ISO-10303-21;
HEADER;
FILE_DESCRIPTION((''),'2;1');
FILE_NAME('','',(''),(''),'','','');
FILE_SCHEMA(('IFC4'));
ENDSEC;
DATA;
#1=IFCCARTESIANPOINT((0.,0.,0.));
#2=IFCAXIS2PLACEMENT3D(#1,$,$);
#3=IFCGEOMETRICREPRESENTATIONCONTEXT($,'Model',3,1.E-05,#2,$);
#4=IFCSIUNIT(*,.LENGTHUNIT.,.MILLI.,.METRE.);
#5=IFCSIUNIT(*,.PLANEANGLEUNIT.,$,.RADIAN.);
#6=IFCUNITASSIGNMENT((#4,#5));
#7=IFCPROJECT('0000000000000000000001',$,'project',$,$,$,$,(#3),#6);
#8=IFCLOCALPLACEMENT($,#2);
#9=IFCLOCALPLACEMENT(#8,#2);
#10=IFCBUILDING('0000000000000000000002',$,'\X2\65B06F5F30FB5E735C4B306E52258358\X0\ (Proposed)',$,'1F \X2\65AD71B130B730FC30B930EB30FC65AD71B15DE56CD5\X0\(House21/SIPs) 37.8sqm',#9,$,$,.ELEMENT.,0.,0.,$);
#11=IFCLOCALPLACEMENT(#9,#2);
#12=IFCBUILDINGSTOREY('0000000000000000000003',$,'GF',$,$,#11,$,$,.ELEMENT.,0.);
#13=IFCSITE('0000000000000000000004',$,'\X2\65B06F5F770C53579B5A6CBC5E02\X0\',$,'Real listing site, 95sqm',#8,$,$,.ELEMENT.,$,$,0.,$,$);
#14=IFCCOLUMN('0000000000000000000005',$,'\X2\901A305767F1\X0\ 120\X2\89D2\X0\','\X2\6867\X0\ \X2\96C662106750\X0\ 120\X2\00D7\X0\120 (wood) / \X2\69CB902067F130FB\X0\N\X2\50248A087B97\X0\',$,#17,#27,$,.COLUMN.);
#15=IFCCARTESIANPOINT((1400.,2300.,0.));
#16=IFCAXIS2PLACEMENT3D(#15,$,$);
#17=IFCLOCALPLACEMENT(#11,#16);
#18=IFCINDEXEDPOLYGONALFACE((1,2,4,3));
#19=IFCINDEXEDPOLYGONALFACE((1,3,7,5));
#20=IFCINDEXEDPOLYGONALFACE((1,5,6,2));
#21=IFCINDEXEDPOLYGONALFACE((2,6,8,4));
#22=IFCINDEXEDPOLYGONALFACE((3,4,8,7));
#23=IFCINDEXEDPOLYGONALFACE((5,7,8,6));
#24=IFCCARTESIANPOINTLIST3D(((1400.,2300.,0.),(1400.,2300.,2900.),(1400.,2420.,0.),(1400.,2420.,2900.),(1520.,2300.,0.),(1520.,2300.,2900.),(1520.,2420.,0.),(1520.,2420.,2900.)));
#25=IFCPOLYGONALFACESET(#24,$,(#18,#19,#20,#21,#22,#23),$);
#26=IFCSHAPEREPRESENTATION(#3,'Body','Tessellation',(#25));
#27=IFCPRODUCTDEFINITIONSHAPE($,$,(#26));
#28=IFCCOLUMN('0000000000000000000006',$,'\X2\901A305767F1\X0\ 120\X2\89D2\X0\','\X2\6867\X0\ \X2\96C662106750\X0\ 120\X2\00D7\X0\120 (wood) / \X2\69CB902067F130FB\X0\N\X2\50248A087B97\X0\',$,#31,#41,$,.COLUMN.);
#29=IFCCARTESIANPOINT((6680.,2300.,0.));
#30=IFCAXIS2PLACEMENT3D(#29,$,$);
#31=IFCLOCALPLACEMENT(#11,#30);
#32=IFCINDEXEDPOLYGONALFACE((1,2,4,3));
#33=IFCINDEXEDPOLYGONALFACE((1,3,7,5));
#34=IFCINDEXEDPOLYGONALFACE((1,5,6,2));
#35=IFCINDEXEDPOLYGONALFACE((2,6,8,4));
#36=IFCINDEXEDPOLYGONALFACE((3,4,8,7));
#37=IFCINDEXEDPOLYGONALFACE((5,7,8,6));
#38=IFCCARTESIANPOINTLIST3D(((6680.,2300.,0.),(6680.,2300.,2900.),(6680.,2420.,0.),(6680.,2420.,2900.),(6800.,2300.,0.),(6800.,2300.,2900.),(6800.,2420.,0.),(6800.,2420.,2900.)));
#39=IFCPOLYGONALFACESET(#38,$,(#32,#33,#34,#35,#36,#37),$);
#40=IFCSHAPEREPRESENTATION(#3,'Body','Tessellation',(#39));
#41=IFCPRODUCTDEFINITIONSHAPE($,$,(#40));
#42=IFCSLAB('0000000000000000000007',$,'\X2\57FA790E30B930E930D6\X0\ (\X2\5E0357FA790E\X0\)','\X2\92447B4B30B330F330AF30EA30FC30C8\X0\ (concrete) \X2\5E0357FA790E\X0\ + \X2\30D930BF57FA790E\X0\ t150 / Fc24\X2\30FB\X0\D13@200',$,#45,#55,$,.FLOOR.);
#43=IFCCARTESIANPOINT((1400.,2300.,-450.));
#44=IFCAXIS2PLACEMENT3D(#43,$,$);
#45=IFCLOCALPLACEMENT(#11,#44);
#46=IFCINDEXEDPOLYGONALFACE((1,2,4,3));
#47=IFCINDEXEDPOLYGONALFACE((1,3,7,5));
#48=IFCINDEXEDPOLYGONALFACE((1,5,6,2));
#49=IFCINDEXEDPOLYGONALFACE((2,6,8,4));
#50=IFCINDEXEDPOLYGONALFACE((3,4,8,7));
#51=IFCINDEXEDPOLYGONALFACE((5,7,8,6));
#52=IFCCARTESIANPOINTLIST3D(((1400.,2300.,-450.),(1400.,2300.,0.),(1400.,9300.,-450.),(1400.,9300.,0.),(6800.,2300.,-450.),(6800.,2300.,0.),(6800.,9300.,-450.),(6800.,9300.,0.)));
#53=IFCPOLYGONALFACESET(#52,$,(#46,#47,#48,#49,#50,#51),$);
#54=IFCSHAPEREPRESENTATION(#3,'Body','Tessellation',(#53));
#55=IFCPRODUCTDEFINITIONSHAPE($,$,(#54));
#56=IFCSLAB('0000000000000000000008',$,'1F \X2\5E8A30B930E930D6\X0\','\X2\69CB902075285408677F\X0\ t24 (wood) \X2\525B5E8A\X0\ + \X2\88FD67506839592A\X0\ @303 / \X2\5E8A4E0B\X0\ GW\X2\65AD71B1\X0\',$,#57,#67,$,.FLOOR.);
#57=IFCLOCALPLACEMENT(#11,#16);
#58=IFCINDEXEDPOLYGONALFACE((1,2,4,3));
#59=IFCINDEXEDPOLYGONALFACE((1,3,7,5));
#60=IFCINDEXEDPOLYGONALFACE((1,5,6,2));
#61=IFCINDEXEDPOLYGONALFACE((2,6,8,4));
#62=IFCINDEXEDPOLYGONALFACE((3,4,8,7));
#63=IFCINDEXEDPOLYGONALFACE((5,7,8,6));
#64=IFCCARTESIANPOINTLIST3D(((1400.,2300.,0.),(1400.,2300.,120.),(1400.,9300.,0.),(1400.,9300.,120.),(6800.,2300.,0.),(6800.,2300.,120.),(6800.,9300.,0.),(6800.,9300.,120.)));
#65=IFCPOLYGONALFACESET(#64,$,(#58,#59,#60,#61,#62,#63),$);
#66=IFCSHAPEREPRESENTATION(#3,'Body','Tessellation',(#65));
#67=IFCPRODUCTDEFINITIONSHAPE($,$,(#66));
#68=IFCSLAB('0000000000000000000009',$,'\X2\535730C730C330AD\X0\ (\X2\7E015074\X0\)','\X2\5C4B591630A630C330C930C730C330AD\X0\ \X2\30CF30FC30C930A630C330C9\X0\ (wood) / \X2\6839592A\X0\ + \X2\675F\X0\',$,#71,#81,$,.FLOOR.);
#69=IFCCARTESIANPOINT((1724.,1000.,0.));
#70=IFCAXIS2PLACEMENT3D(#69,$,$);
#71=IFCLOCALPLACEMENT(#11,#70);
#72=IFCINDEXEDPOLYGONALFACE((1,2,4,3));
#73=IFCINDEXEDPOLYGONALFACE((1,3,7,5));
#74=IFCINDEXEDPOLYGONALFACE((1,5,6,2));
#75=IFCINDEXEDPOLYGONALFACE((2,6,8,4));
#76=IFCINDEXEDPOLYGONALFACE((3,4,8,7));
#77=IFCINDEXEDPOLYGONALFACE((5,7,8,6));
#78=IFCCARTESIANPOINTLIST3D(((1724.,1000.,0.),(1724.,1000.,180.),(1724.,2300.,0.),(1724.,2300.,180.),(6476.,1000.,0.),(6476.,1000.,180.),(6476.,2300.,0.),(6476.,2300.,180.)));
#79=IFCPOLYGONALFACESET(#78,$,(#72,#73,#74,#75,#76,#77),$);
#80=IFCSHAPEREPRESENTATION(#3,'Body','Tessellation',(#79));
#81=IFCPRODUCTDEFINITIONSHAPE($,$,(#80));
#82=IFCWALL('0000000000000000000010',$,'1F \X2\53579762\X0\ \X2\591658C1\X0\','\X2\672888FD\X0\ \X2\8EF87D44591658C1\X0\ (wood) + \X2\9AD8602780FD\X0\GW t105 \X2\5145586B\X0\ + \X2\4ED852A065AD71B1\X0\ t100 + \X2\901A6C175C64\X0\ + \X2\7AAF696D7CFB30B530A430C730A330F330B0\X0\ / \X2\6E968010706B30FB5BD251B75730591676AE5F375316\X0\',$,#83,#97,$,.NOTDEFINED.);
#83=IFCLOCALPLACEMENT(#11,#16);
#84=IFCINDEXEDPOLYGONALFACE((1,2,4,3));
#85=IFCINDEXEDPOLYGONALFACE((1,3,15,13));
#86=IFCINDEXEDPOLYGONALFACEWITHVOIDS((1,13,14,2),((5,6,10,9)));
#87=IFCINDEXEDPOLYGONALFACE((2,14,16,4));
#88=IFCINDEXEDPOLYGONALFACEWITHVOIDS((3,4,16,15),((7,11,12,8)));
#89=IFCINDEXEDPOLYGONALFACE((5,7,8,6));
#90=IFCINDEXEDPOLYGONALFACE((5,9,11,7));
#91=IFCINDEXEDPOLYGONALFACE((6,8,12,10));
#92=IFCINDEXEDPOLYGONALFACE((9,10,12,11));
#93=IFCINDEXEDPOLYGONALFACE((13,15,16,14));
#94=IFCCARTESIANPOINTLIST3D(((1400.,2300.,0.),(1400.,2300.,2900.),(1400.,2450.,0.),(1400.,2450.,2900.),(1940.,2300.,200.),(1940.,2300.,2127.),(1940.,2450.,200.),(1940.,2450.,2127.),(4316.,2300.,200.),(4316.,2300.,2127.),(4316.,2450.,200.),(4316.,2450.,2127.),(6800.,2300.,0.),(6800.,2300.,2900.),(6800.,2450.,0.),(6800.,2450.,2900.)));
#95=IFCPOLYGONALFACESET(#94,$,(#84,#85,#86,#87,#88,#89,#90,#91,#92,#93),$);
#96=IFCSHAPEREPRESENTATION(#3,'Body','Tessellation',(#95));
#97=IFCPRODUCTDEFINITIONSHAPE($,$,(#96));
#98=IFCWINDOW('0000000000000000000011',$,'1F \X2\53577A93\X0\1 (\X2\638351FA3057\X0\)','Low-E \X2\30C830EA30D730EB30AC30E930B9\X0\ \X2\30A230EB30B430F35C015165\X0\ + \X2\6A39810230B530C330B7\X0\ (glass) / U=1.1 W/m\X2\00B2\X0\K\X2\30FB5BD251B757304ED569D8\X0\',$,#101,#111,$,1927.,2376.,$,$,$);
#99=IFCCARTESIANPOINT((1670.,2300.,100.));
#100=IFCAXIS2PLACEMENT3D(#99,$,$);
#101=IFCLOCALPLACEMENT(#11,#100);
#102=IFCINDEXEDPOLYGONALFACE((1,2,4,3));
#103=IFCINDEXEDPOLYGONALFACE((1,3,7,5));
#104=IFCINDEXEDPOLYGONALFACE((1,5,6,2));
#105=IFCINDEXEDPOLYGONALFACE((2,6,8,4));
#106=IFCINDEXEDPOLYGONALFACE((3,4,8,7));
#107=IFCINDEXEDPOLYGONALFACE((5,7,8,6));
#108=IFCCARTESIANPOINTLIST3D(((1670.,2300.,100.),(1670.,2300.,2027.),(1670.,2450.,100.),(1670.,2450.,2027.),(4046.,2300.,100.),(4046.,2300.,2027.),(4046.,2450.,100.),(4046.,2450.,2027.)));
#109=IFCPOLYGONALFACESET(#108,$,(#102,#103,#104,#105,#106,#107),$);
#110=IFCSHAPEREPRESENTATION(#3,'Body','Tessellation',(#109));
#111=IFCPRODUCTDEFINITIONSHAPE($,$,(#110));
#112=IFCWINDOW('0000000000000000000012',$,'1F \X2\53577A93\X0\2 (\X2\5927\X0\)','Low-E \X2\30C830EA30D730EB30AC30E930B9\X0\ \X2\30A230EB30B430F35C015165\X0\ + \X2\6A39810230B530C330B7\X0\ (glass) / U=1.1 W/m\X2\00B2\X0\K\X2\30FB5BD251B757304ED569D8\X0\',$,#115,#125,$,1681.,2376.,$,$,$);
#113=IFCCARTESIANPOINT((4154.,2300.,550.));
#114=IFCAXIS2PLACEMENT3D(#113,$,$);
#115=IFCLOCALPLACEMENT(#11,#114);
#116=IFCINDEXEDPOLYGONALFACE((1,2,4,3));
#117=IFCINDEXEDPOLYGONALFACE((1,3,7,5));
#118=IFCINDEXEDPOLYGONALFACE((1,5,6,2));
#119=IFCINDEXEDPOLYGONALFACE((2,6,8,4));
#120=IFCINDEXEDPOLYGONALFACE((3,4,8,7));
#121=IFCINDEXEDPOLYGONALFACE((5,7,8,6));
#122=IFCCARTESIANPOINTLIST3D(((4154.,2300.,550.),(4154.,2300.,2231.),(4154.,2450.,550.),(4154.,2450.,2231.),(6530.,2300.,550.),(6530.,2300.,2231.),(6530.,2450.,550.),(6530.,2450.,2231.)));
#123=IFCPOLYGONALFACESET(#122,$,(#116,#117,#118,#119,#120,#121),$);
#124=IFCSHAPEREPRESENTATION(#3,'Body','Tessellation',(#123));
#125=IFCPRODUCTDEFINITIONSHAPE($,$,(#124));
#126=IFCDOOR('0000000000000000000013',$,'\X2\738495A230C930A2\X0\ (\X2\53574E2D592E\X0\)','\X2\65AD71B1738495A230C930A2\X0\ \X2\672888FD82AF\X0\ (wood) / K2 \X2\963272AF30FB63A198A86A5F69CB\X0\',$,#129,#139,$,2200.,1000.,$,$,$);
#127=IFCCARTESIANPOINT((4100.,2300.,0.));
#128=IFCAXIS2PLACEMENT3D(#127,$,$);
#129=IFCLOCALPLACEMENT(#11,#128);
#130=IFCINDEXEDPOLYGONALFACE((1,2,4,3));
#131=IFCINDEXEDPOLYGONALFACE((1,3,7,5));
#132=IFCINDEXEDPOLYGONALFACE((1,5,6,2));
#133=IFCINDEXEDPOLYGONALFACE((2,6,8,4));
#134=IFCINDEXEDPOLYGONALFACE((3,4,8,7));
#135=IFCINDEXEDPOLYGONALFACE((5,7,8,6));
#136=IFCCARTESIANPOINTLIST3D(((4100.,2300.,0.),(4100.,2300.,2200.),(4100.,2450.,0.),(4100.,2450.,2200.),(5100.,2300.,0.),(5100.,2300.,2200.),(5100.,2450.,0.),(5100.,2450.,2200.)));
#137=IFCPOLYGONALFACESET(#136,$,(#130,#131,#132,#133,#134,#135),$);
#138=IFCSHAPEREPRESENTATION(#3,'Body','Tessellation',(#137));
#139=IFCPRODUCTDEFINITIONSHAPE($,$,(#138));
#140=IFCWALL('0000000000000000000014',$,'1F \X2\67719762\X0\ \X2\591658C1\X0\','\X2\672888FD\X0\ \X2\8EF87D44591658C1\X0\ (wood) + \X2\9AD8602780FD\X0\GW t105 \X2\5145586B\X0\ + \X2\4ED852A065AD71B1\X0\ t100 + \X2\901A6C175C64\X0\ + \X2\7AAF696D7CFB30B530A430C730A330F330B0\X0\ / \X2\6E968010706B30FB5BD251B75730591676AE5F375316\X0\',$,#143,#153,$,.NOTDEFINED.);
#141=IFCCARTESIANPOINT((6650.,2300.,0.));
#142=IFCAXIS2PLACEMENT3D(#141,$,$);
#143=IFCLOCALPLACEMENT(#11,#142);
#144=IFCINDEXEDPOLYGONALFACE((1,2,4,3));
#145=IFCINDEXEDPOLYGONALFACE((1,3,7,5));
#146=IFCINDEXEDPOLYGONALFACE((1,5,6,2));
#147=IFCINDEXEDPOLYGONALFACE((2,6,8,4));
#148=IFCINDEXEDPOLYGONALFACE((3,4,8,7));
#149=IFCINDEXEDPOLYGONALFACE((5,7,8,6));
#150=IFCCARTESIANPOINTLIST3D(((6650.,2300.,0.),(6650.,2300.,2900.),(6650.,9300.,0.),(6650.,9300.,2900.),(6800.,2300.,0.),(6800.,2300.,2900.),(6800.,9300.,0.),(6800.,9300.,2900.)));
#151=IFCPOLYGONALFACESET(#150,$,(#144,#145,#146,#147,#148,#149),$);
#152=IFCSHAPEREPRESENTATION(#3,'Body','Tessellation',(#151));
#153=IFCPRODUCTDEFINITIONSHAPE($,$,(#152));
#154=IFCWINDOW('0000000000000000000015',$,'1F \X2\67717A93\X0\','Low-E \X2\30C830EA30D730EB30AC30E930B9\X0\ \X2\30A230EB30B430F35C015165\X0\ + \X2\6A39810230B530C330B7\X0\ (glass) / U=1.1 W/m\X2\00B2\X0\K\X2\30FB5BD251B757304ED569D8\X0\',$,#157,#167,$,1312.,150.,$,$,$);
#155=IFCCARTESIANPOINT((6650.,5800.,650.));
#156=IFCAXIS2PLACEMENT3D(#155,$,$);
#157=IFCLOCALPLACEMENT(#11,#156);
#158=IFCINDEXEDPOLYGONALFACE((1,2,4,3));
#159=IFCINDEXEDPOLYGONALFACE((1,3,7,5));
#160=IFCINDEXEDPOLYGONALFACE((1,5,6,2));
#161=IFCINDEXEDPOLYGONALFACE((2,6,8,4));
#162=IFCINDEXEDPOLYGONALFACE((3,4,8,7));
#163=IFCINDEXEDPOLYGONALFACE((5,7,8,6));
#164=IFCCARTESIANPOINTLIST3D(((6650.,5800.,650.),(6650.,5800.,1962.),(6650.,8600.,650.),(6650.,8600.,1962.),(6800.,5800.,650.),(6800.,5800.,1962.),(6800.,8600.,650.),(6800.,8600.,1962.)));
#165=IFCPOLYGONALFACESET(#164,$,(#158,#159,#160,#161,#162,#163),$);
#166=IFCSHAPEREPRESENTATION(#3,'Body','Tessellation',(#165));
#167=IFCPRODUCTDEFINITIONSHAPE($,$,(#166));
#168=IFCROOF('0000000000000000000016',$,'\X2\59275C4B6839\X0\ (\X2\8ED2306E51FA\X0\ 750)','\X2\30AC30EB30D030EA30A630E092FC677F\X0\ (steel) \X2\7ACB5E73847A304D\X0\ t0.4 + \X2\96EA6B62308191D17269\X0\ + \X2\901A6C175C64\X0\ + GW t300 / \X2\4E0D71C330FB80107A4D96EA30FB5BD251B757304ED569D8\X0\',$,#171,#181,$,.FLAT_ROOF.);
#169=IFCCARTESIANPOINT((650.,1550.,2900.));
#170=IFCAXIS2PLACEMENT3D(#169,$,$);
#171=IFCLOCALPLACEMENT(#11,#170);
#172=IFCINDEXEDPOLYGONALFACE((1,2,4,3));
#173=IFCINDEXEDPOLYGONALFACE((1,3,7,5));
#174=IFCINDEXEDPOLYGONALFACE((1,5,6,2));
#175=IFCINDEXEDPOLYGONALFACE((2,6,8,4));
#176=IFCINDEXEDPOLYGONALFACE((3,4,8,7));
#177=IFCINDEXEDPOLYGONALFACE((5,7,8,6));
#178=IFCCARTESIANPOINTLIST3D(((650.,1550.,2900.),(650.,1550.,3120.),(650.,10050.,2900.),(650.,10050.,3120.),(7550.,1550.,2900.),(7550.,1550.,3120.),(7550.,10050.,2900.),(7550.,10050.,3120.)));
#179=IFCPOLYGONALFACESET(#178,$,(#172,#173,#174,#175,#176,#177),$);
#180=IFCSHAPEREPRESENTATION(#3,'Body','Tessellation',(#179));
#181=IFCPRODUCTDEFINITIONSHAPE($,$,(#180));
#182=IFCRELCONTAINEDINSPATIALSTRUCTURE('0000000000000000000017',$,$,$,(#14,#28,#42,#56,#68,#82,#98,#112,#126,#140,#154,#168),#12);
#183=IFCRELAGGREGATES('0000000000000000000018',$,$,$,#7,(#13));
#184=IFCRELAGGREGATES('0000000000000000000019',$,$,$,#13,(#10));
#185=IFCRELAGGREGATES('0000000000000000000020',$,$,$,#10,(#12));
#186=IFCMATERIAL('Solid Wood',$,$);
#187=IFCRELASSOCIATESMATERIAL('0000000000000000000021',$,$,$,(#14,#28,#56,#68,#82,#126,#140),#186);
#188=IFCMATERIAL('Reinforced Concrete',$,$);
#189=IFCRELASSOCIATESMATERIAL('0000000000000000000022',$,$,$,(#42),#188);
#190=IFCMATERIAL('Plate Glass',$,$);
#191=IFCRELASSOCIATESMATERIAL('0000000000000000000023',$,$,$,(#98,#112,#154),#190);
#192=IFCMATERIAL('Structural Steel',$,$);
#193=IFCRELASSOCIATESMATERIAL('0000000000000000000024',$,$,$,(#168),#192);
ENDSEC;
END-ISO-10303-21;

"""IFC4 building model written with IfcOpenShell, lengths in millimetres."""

from ifc_helpers import new_model, si_unit, frame, frame_2d, origin, place, context, project, spatial, rectangle, extrude, material, element, fill, save


model = new_model("IFC4")

# Units and contexts
model_context = context("Model", 3, precision=1e-05, world=origin())
ifc_project = project(units=[si_unit("LENGTHUNIT", "METRE", prefix="MILLI"), si_unit("PLANEANGLEUNIT", "RADIAN")], contexts=[model_context])

# Site, building, storey
site_placement = place(None, origin())
site = spatial("IfcSite", under=ifc_project, at=site_placement, Name="新潟県南魚沼市", ObjectType="Real listing site, 95sqm", CompositionType="ELEMENT", RefElevation=0.0)
building_placement = place(site_placement, origin())
building = spatial("IfcBuilding", under=site, at=building_placement, Name="新潟・平屋の別荘 (Proposed)", ObjectType="1F 断熱シースルー断熱工法(House21/SIPs) 37.8sqm", CompositionType="ELEMENT", ElevationOfRefHeight=0.0, ElevationOfTerrain=0.0)
storey_placement = place(building_placement, origin())
storey = spatial("IfcBuildingStorey", under=building, at=storey_placement, Name="GF", CompositionType="ELEMENT", Elevation=0.0)

# Columns
ifc_material_1 = material(Name="Solid Wood")
column_1_placement = place(storey_placement, frame((1400.0, 2300.0, 0.0)))
element("IfcColumn", 1, at=column_1_placement, inside=storey, material=ifc_material_1, Name="通し柱 120角", Description="桧 集成材 120×120 (wood) / 構造柱・N値計算", PredefinedType="COLUMN", context=model_context, shape_type="SweptSolid", body=[
    extrude(rectangle(XDim=120.0, YDim=120.0, at=frame_2d((60.0, 60.0))), frame((1400.0, 2300.0, 0.0)), (0.0, 0.0, 1.0), 2900.0),
])
column_2_placement = place(storey_placement, frame((6680.0, 2300.0, 0.0)))
element("IfcColumn", 2, at=column_2_placement, inside=storey, material=ifc_material_1, Name="通し柱 120角", Description="桧 集成材 120×120 (wood) / 構造柱・N値計算", PredefinedType="COLUMN", context=model_context, shape_type="SweptSolid", body=[
    extrude(rectangle(XDim=120.0, YDim=120.0, at=frame_2d((60.0, 60.0))), frame((6680.0, 2300.0, 0.0)), (0.0, 0.0, 1.0), 2900.0),
])

# Slabs
ifc_material_2 = material(Name="Reinforced Concrete")
slab_1_placement = place(storey_placement, frame((1400.0, 2300.0, -450.0)))
element("IfcSlab", 3, at=slab_1_placement, inside=storey, material=ifc_material_2, Name="基礎スラブ (布基礎)", Description="鉄筋コンクリート (concrete) 布基礎 + ベタ基礎 t150 / Fc24・D13@200", PredefinedType="FLOOR", context=model_context, shape_type="SweptSolid", body=[
    extrude(rectangle(XDim=5400.0, YDim=7000.0, at=frame_2d((2700.0, 3500.0))), frame((1400.0, 2300.0, -450.0)), (0.0, 0.0, 1.0), 450.0),
])
slab_2_placement = place(storey_placement, frame((1400.0, 2300.0, 0.0)))
element("IfcSlab", 4, at=slab_2_placement, inside=storey, material=ifc_material_1, Name="1F 床スラブ", Description="構造用合板 t24 (wood) 剛床 + 製材根太 @303 / 床下 GW断熱", PredefinedType="FLOOR", context=model_context, shape_type="SweptSolid", body=[
    extrude(rectangle(XDim=5400.0, YDim=7000.0, at=frame_2d((2700.0, 3500.0))), frame((1400.0, 2300.0, 0.0)), (0.0, 0.0, 1.0), 120.0),
])
slab_3_placement = place(storey_placement, frame((1724.0, 1000.0, 0.0)))
element("IfcSlab", 5, at=slab_3_placement, inside=storey, material=ifc_material_1, Name="南デッキ (縁側)", Description="屋外ウッドデッキ ハードウッド (wood) / 根太 + 束", PredefinedType="FLOOR", context=model_context, shape_type="SweptSolid", body=[
    extrude(rectangle(XDim=4752.0, YDim=1300.0, at=frame_2d((2376.0, 650.0))), frame((1724.0, 1000.0, 0.0)), (0.0, 0.0, 1.0), 180.0),
])

# Wall, openings, windows, door
wall_1_placement = place(storey_placement, frame((1400.0, 2300.0, 0.0)))
wall_1 = element("IfcWall", 6, at=wall_1_placement, inside=storey, material=ifc_material_1, Name="1F 南面 外壁", Description="木製 軸組外壁 (wood) + 高性能GW t105 充填 + 付加断熱 t100 + 通気層 + 窯業系サイディング / 準耐火・寒冷地外皮強化", PredefinedType="NOTDEFINED", context=model_context, shape_type="SweptSolid", body=[
    extrude(rectangle(XDim=5400.0, YDim=150.0, at=frame_2d((2700.0, 75.0))), frame((1400.0, 2300.0, 0.0)), (0.0, 0.0, 1.0), 2900.0),
])
opening_1_placement = place(storey_placement, frame((1670.0, 2300.0, 100.0)))
opening_1 = element("IfcOpeningElement", 7, at=opening_1_placement, cuts=wall_1, PredefinedType="NOTDEFINED", context=model_context, shape_type="SweptSolid", body=[
    extrude(rectangle(XDim=2376.0, YDim=150.0, at=frame_2d((1188.0, 75.0))), frame((1670.0, 2300.0, 100.0)), (0.0, 0.0, 1.0), 1927.0),
])
opening_2_placement = place(storey_placement, frame((4154.0, 2300.0, 550.0)))
opening_2 = element("IfcOpeningElement", 8, at=opening_2_placement, cuts=wall_1, PredefinedType="NOTDEFINED", context=model_context, shape_type="SweptSolid", body=[
    extrude(rectangle(XDim=2376.0, YDim=150.0, at=frame_2d((1188.0, 75.0))), frame((4154.0, 2300.0, 550.0)), (0.0, 0.0, 1.0), 1681.0),
])
opening_3_placement = place(storey_placement, frame((4100.0, 2300.0, 0.0)))
opening_3 = element("IfcOpeningElement", 9, at=opening_3_placement, cuts=wall_1, PredefinedType="NOTDEFINED", context=model_context, shape_type="SweptSolid", body=[
    extrude(rectangle(XDim=1000.0, YDim=150.0, at=frame_2d((500.0, 75.0))), frame((4100.0, 2300.0, 0.0)), (0.0, 0.0, 1.0), 2200.0),
])
ifc_material_3 = material(Name="Plate Glass")
window_1_placement = place(storey_placement, frame((1670.0, 2300.0, 100.0)))
window_1 = element("IfcWindow", 10, at=window_1_placement, inside=storey, material=ifc_material_3, Name="1F 南窓1 (掃出し)", Description="Low-E トリプルガラス アルゴン封入 + 樹脂サッシ (glass) / U=1.1 W/m²K・寒冷地仕様", OverallHeight=1927.0, OverallWidth=2376.0, context=model_context, shape_type="SweptSolid", body=[
    extrude(rectangle(XDim=2376.0, YDim=150.0, at=frame_2d((1188.0, 75.0))), frame((1670.0, 2300.0, 100.0)), (0.0, 0.0, 1.0), 1927.0),
])
fill(opening_1, window_1)
window_2_placement = place(storey_placement, frame((4154.0, 2300.0, 550.0)))
window_2 = element("IfcWindow", 11, at=window_2_placement, inside=storey, material=ifc_material_3, Name="1F 南窓2 (大)", Description="Low-E トリプルガラス アルゴン封入 + 樹脂サッシ (glass) / U=1.1 W/m²K・寒冷地仕様", OverallHeight=1681.0, OverallWidth=2376.0, context=model_context, shape_type="SweptSolid", body=[
    extrude(rectangle(XDim=2376.0, YDim=150.0, at=frame_2d((1188.0, 75.0))), frame((4154.0, 2300.0, 550.0)), (0.0, 0.0, 1.0), 1681.0),
])
fill(opening_2, window_2)
door_placement = place(storey_placement, frame((4100.0, 2300.0, 0.0)))
door = element("IfcDoor", 12, at=door_placement, inside=storey, material=ifc_material_1, Name="玄関ドア (南中央)", Description="断熱玄関ドア 木製芯 (wood) / K2 防犯・採風機構", OverallHeight=2200.0, OverallWidth=1000.0, context=model_context, shape_type="SweptSolid", body=[
    extrude(rectangle(XDim=1000.0, YDim=150.0, at=frame_2d((500.0, 75.0))), frame((4100.0, 2300.0, 0.0)), (0.0, 0.0, 1.0), 2200.0),
])
fill(opening_3, door)

# Wall, opening, window
wall_2_placement = place(storey_placement, frame((6650.0, 2300.0, 0.0)))
wall_2 = element("IfcWall", 13, at=wall_2_placement, inside=storey, material=ifc_material_1, Name="1F 東面 外壁", Description="木製 軸組外壁 (wood) + 高性能GW t105 充填 + 付加断熱 t100 + 通気層 + 窯業系サイディング / 準耐火・寒冷地外皮強化", PredefinedType="NOTDEFINED", context=model_context, shape_type="SweptSolid", body=[
    extrude(rectangle(XDim=150.0, YDim=7000.0, at=frame_2d((75.0, 3500.0))), frame((6650.0, 2300.0, 0.0)), (0.0, 0.0, 1.0), 2900.0),
])
opening_4_placement = place(storey_placement, frame((6650.0, 5800.0, 650.0)))
opening_4 = element("IfcOpeningElement", 14, at=opening_4_placement, cuts=wall_2, PredefinedType="NOTDEFINED", context=model_context, shape_type="SweptSolid", body=[
    extrude(rectangle(XDim=150.0, YDim=2800.0, at=frame_2d((75.0, 1400.0))), frame((6650.0, 5800.0, 650.0)), (0.0, 0.0, 1.0), 1312.0),
])
window_3_placement = place(storey_placement, frame((6650.0, 5800.0, 650.0)))
window_3 = element("IfcWindow", 15, at=window_3_placement, inside=storey, material=ifc_material_3, Name="1F 東窓", Description="Low-E トリプルガラス アルゴン封入 + 樹脂サッシ (glass) / U=1.1 W/m²K・寒冷地仕様", OverallHeight=1312.0, OverallWidth=150.0, context=model_context, shape_type="SweptSolid", body=[
    extrude(rectangle(XDim=150.0, YDim=2800.0, at=frame_2d((75.0, 1400.0))), frame((6650.0, 5800.0, 650.0)), (0.0, 0.0, 1.0), 1312.0),
])
fill(opening_4, window_3)

# Roof
ifc_material_4 = material(Name="Structural Steel")
roof_placement = place(storey_placement, frame((650.0, 1550.0, 2900.0)))
element("IfcRoof", 16, at=roof_placement, inside=storey, material=ifc_material_4, Name="大屋根 (軒の出 750)", Description="ガルバリウム鋼板 (steel) 立平葺き t0.4 + 雪止め金物 + 通気層 + GW t300 / 不燃・耐積雪・寒冷地仕様", PredefinedType="FLAT_ROOF", context=model_context, shape_type="SweptSolid", body=[
    extrude(rectangle(XDim=6900.0, YDim=8500.0, at=frame_2d((3450.0, 4250.0))), frame((650.0, 1550.0, 2900.0)), (0.0, 0.0, 1.0), 220.0),
])

save(model, "model.ifc")
